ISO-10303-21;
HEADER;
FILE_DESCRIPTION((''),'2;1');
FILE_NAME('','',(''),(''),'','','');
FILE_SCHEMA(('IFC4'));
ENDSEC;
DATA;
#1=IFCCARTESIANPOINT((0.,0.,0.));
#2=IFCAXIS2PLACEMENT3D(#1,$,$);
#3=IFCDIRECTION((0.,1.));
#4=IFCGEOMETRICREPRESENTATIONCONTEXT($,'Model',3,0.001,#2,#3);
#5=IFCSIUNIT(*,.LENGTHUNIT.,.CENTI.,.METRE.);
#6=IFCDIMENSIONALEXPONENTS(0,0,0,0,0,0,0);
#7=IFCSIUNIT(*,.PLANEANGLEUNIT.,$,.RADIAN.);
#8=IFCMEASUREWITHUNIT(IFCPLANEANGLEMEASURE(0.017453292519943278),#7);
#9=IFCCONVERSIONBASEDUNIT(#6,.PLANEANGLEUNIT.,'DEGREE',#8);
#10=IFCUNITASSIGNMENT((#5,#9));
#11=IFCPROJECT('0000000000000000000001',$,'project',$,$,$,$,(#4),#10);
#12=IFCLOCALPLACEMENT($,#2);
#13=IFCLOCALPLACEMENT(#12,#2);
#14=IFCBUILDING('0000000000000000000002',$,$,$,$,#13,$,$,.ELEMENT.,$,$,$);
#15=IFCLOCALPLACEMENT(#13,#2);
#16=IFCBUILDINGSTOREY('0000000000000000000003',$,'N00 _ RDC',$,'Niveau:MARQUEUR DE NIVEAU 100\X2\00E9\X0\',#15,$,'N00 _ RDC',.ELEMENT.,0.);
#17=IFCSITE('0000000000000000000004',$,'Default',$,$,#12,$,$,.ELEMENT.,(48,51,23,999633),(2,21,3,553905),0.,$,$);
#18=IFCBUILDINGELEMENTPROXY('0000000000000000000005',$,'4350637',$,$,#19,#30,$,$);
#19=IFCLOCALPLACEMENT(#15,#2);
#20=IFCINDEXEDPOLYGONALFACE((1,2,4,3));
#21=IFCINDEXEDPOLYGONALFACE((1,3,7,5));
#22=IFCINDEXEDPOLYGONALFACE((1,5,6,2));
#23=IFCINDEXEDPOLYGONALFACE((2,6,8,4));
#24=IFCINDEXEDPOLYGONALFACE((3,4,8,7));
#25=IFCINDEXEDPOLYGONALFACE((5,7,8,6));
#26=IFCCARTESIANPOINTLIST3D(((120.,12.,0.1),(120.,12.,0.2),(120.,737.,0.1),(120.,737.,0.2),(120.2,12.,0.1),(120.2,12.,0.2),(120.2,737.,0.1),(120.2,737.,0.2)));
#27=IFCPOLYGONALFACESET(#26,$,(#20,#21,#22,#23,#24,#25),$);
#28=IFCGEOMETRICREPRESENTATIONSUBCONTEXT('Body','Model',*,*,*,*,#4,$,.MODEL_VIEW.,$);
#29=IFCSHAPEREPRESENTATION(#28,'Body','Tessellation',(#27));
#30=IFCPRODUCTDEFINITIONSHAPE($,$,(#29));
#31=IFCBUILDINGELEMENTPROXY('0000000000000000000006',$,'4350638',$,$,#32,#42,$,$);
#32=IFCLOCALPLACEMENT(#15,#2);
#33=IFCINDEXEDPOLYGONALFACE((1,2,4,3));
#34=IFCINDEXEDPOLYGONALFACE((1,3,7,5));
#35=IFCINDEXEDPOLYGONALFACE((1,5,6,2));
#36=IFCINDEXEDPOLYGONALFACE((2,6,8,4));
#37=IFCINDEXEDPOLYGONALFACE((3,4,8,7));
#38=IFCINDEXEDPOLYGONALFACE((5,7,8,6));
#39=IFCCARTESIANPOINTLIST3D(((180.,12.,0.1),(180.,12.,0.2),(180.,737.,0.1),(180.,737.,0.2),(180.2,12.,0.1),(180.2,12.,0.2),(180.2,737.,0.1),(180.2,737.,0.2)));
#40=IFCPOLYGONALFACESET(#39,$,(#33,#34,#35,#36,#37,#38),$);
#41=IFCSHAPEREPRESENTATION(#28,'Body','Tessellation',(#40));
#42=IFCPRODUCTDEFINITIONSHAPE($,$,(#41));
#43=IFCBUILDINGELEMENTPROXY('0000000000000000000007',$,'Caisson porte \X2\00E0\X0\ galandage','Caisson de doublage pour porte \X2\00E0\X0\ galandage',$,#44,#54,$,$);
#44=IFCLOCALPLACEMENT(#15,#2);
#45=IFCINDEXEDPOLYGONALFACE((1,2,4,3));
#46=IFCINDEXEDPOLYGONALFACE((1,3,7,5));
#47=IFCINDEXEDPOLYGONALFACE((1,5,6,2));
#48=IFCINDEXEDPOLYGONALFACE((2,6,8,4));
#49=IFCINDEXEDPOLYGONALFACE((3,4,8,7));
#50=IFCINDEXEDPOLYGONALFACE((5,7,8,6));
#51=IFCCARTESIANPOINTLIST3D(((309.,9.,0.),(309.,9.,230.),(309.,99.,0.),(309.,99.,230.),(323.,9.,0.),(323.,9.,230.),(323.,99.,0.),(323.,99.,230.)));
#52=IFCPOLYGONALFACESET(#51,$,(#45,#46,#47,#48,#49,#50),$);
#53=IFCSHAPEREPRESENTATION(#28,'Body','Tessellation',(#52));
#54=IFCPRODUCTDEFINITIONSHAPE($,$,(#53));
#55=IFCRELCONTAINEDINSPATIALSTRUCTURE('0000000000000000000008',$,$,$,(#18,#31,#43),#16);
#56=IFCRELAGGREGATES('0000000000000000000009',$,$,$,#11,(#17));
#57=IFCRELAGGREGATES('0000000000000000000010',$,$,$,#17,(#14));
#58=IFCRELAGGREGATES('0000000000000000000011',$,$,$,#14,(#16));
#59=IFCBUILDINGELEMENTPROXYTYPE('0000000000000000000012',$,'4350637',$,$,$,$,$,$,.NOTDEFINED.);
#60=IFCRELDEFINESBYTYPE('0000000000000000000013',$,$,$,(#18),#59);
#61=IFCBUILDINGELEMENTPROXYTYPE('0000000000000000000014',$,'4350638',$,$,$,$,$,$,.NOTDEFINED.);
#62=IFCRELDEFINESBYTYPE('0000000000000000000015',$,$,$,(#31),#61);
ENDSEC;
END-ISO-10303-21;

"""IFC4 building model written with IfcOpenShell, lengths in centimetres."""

from ifc_helpers import new_model, entity, si_unit, converted_unit, direction, frame, frame_2d, origin, origin_with_axes, origin_2d_with_axis, place, context, subcontext, project, spatial, rectangle, extrude, type_object, element, save


model = new_model("IFC4")

# Units and contexts
model_context = context("Model", 3, precision=0.001, world=origin(), true_north=direction((0.0, 1.0)))
body_context = subcontext(model_context, "Body", "Model", "MODEL_VIEW")
ifc_project = project(units=[si_unit("LENGTHUNIT", "METRE", prefix="CENTI"), converted_unit("PLANEANGLEUNIT", "DEGREE", entity("IfcPlaneAngleMeasure", 0.017453292519943278), si_unit("PLANEANGLEUNIT", "RADIAN"), dimensions=[0, 0, 0, 0, 0, 0, 0])], contexts=[model_context])

# Site, building, storey
site_placement = place(None, origin())
site = spatial("IfcSite", under=ifc_project, at=site_placement, Name="Default", CompositionType="ELEMENT", RefLatitude=(48, 51, 23, 999633), RefLongitude=(2, 21, 3, 553905), RefElevation=0.0)
building_placement = place(site_placement, origin())
building = spatial("IfcBuilding", under=site, at=building_placement, CompositionType="ELEMENT")
storey_placement = place(building_placement, origin())
storey = spatial("IfcBuildingStorey", under=building, at=storey_placement, Name="N00 _ RDC", ObjectType="Niveau:MARQUEUR DE NIVEAU 100é", LongName="N00 _ RDC", CompositionType="ELEMENT", Elevation=0.0)

# Building element proxies
building_element_proxy_type_1 = type_object("IfcBuildingElementProxyType", Name="4350637", PredefinedType="NOTDEFINED")
proxy_1_placement = place(storey_placement, origin())
element("IfcBuildingElementProxy", 1, at=proxy_1_placement, inside=storey, type_object=building_element_proxy_type_1, Name="4350637", context=body_context, shape_type="SweptSolid", body=[
    extrude(rectangle(XDim=0.2, YDim=725.0, at=frame_2d((0.0, 0.0), x_axis=(1.0, 0.0))), frame((120.1, 374.5, 0.1)), (0.0, 0.0, 1.0), 0.1),
])
building_element_proxy_type_2 = type_object("IfcBuildingElementProxyType", Name="4350638", PredefinedType="NOTDEFINED")
proxy_2_placement = place(storey_placement, origin())
element("IfcBuildingElementProxy", 2, at=proxy_2_placement, inside=storey, type_object=building_element_proxy_type_2, Name="4350638", context=body_context, shape_type="SweptSolid", body=[
    extrude(rectangle(XDim=0.2, YDim=725.0, at=origin_2d_with_axis()), frame((180.1, 374.5, 0.1)), (0.0, 0.0, 1.0), 0.1),
])
proxy_3_placement = place(storey_placement, origin_with_axes())
element("IfcBuildingElementProxy", 3, at=proxy_3_placement, inside=storey, Name="Caisson porte à galandage", Description="Caisson de doublage pour porte à galandage", context=body_context, shape_type="SweptSolid", body=[
    extrude(rectangle(XDim=14.0, YDim=90.0, at=frame_2d((316.0, 54.0))), origin(), (0.0, 0.0, 1.0), 230.0),
])

save(model, "model.ifc")
